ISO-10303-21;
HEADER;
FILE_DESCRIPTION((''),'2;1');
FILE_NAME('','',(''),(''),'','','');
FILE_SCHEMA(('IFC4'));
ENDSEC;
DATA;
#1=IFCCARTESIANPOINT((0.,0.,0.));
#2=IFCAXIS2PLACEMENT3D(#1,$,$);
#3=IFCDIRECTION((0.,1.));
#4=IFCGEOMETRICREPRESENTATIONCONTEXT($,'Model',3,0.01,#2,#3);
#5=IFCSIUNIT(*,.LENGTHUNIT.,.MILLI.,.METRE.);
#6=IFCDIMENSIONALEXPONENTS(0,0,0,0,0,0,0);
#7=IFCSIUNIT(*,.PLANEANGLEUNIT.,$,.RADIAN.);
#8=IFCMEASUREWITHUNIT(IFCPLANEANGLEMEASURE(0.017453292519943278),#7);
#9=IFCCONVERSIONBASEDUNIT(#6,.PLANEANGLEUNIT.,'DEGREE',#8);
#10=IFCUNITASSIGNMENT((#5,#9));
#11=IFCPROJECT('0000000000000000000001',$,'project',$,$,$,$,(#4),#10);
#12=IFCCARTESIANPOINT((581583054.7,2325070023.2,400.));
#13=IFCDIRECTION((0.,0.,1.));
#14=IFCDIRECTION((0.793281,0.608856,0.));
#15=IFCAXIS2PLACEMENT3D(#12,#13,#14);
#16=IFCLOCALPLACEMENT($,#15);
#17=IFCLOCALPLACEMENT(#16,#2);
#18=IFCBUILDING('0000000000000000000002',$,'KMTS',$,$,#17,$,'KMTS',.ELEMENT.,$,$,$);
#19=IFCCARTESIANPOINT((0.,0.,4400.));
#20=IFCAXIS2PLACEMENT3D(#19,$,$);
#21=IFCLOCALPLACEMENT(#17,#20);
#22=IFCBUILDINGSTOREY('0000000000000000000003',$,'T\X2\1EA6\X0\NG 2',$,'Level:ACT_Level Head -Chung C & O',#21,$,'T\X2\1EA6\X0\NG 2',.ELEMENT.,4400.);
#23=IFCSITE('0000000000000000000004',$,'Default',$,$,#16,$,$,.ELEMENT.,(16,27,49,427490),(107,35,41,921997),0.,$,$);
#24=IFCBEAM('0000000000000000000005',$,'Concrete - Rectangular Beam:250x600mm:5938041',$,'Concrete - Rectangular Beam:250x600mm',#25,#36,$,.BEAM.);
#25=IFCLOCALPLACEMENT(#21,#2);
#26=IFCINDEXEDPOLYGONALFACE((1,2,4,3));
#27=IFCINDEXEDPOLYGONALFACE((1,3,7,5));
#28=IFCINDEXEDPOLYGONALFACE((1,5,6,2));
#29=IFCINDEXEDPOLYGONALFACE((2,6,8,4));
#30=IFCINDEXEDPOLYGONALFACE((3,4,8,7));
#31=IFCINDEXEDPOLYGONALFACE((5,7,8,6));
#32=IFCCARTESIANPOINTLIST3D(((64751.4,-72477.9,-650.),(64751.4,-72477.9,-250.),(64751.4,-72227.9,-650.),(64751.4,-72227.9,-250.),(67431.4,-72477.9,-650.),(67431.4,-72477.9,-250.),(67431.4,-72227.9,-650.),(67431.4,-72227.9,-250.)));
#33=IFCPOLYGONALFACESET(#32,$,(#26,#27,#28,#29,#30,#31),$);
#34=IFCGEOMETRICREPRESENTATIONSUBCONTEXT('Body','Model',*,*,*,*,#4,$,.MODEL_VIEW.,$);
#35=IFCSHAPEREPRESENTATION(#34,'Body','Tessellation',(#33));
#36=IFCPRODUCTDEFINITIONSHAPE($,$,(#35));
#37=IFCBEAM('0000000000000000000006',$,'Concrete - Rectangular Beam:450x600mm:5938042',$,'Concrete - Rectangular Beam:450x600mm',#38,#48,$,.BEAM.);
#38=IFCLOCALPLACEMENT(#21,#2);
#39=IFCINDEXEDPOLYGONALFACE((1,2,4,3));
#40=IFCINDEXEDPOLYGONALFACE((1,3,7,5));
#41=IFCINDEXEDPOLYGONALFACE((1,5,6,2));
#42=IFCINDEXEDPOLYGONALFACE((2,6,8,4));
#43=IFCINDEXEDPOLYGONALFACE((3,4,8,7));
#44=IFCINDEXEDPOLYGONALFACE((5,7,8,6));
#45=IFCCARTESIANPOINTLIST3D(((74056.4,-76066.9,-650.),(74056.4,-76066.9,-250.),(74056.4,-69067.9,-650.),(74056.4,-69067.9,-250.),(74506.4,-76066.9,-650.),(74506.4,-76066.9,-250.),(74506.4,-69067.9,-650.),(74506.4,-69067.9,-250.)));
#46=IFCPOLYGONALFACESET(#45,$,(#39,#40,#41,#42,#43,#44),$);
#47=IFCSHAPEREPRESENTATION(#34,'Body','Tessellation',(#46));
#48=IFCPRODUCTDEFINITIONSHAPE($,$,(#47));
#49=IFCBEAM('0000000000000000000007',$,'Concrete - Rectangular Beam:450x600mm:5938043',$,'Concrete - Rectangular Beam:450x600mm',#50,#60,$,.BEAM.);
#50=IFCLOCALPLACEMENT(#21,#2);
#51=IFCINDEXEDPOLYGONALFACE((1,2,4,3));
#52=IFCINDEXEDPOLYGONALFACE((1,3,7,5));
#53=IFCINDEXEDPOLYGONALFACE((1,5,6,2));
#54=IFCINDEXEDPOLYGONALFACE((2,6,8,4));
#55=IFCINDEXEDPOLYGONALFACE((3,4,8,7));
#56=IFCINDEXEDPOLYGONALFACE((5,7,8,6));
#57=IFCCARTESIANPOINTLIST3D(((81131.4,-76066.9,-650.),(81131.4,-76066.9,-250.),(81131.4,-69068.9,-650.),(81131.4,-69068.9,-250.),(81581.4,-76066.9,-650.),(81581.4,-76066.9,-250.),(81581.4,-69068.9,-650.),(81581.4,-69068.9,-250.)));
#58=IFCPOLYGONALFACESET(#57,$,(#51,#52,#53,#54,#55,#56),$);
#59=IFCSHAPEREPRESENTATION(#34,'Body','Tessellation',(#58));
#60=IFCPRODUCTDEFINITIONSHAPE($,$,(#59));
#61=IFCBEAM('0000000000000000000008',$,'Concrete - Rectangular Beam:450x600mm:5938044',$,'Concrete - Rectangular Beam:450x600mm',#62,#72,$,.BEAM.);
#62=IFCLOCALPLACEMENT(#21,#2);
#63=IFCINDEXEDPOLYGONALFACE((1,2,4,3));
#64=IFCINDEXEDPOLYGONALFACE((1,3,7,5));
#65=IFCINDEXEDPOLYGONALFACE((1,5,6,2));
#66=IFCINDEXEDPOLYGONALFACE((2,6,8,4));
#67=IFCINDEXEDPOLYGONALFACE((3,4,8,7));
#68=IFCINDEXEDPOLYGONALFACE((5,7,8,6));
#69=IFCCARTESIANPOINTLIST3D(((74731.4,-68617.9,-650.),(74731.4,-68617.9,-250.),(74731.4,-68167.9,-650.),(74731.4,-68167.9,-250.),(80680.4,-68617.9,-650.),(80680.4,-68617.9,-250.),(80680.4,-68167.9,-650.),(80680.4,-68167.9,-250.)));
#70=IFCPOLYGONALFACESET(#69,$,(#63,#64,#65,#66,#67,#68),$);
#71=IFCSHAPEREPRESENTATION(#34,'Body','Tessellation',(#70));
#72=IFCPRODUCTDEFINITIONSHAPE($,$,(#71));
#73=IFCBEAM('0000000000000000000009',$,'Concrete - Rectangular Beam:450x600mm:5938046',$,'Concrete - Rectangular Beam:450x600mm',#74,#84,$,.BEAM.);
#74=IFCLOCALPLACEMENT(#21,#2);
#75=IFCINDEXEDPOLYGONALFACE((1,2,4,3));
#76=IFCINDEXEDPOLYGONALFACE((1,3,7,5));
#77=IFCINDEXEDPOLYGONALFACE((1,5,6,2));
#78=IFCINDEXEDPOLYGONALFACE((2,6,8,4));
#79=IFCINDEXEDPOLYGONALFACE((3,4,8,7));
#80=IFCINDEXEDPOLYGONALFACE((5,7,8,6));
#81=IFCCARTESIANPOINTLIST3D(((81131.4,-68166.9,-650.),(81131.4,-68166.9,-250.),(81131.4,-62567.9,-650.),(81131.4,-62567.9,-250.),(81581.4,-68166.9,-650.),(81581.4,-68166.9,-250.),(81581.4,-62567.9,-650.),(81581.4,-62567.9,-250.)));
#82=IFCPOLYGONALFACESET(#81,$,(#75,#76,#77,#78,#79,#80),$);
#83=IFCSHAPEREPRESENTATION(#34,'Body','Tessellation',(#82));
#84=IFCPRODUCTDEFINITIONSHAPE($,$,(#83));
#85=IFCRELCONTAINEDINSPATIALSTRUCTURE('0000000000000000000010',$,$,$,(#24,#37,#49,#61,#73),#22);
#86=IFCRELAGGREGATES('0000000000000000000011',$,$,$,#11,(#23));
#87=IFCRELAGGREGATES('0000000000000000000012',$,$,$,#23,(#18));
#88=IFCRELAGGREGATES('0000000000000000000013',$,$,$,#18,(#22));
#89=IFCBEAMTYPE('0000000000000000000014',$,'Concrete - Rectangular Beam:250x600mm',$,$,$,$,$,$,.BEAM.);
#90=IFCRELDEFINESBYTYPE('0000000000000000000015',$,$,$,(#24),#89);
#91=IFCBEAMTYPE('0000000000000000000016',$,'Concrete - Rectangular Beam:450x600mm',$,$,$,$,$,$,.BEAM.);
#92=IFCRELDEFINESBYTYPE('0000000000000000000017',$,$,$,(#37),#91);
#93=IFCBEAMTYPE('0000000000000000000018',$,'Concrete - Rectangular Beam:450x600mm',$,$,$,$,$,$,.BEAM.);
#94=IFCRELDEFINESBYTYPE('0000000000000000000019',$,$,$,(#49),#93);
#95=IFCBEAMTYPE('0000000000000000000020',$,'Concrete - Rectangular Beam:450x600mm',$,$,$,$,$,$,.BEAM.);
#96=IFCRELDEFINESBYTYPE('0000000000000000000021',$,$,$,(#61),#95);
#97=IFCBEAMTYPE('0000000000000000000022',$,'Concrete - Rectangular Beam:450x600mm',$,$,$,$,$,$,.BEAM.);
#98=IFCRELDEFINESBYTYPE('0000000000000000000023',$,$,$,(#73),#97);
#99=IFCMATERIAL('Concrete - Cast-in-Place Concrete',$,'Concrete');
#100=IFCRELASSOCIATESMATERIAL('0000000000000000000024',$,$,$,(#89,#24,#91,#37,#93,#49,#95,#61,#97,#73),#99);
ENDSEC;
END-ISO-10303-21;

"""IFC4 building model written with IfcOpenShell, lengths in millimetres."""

from ifc_helpers import new_model, entity, si_unit, converted_unit, direction, frame, origin, place, context, subcontext, project, spatial, indexed_curve, outline, extrude, source, transform, mapped, material, type_object, type_shapes, element, save


model = new_model("IFC4")

# Units and contexts
model_context = context("Model", 3, precision=0.01, world=origin(), true_north=direction((0.0, 1.0)))
body_context = subcontext(model_context, "Body", "Model", "MODEL_VIEW")
ifc_project = project(units=[si_unit("LENGTHUNIT", "METRE", prefix="MILLI"), converted_unit("PLANEANGLEUNIT", "DEGREE", entity("IfcPlaneAngleMeasure", 0.017453292519943278), si_unit("PLANEANGLEUNIT", "RADIAN"), dimensions=[0, 0, 0, 0, 0, 0, 0])], contexts=[model_context])

# Site, building, storey
site_placement = place(None, frame((581583054.7, 2325070023.2, 400.0), z_axis=(0.0, 0.0, 1.0), x_axis=(0.793281, 0.608856, 0.0)))
site = spatial("IfcSite", under=ifc_project, at=site_placement, Name="Default", CompositionType="ELEMENT", RefLatitude=(16, 27, 49, 427490), RefLongitude=(107, 35, 41, 921997), RefElevation=0.0)
building_placement = place(site_placement, origin())
building = spatial("IfcBuilding", under=site, at=building_placement, Name="KMTS", LongName="KMTS", CompositionType="ELEMENT")
storey_placement = place(building_placement, frame((0.0, 0.0, 4400.0)))
storey = spatial("IfcBuildingStorey", under=building, at=storey_placement, Name="TẦNG 2", ObjectType="Level:ACT_Level Head -Chung C & O", LongName="TẦNG 2", CompositionType="ELEMENT", Elevation=4400.0)

# Beams
ifc_material_1 = material(Name="Concrete - Cast-in-Place Concrete", Category="Concrete")
beam_type_1 = type_object("IfcBeamType", Name="Concrete - Rectangular Beam:250x600mm", PredefinedType="BEAM", material=ifc_material_1)
shared_shape_1 = source(origin(), body_context, "Body", "SweptSolid", [
    extrude(outline(indexed_curve([(-200.0, -125.0), (200.0, -125.0), (200.0, 125.0), (-200.0, 125.0), (-200.0, -125.0)], self_intersect=False)), frame((64751.4, -72352.9, 3950.0), z_axis=(1.0, 0.0, 0.0), x_axis=(0.0, 0.0, -1.0)), (0.0, 0.0, 1.0), 2680.0),
])
type_shapes(beam_type_1, [shared_shape_1])
beam_1_placement = place(storey_placement, frame((0.0, 0.0, -4400.0)))
element("IfcBeam", 1, at=beam_1_placement, inside=storey, type_object=beam_type_1, material=ifc_material_1, Name="Concrete - Rectangular Beam:250x600mm:5938041", ObjectType="Concrete - Rectangular Beam:250x600mm", PredefinedType="BEAM", context=body_context, shape_type="MappedRepresentation", body=[
    mapped(shared_shape_1, transform((0.0, 0.0, 0.0), scale=1.0)),
])
beam_type_2 = type_object("IfcBeamType", Name="Concrete - Rectangular Beam:450x600mm", PredefinedType="BEAM", material=ifc_material_1)
shared_shape_2 = source(origin(), body_context, "Body", "SweptSolid", [
    extrude(outline(indexed_curve([(-225.0, -200.0), (225.0, -200.0), (225.0, 200.0), (-225.0, 200.0), (-225.0, -200.0)], self_intersect=False)), frame((74281.4, -76066.9, 3950.0), z_axis=(0.0, 1.0, 0.0), x_axis=(-1.0, 0.0, 0.0)), (0.0, 0.0, 1.0), 6999.0),
])
type_shapes(beam_type_2, [shared_shape_2])
beam_2_placement = place(storey_placement, frame((0.0, 0.0, -4400.0)))
element("IfcBeam", 2, at=beam_2_placement, inside=storey, type_object=beam_type_2, material=ifc_material_1, Name="Concrete - Rectangular Beam:450x600mm:5938042", ObjectType="Concrete - Rectangular Beam:450x600mm", PredefinedType="BEAM", context=body_context, shape_type="MappedRepresentation", body=[
    mapped(shared_shape_2, transform((0.0, 0.0, 0.0), scale=1.0)),
])
beam_type_3 = type_object("IfcBeamType", Name="Concrete - Rectangular Beam:450x600mm", PredefinedType="BEAM", material=ifc_material_1)
shared_shape_3 = source(origin(), body_context, "Body", "SweptSolid", [
    extrude(outline(indexed_curve([(-225.0, -200.0), (225.0, -200.0), (225.0, 200.0), (-225.0, 200.0), (-225.0, -200.0)], self_intersect=False)), frame((81356.4, -76066.9, 3950.0), z_axis=(0.0, 1.0, 0.0), x_axis=(-1.0, 0.0, 0.0)), (0.0, 0.0, 1.0), 6998.0),
])
type_shapes(beam_type_3, [shared_shape_3])
beam_3_placement = place(storey_placement, frame((0.0, 0.0, -4400.0)))
element("IfcBeam", 3, at=beam_3_placement, inside=storey, type_object=beam_type_3, material=ifc_material_1, Name="Concrete - Rectangular Beam:450x600mm:5938043", ObjectType="Concrete - Rectangular Beam:450x600mm", PredefinedType="BEAM", context=body_context, shape_type="MappedRepresentation", body=[
    mapped(shared_shape_3, transform((0.0, 0.0, 0.0), scale=1.0)),
])
beam_type_4 = type_object("IfcBeamType", Name="Concrete - Rectangular Beam:450x600mm", PredefinedType="BEAM", material=ifc_material_1)
shared_shape_4 = source(origin(), body_context, "Body", "SweptSolid", [
    extrude(outline(indexed_curve([(-200.0, -225.0), (200.0, -225.0), (200.0, 225.0), (-200.0, 225.0), (-200.0, -225.0)], self_intersect=False)), frame((74731.4, -68392.9, 3950.0), z_axis=(1.0, 0.0, 0.0), x_axis=(0.0, 0.0, -1.0)), (0.0, 0.0, 1.0), 5949.0),
])
type_shapes(beam_type_4, [shared_shape_4])
beam_4_placement = place(storey_placement, frame((0.0, 0.0, -4400.0)))
element("IfcBeam", 4, at=beam_4_placement, inside=storey, type_object=beam_type_4, material=ifc_material_1, Name="Concrete - Rectangular Beam:450x600mm:5938044", ObjectType="Concrete - Rectangular Beam:450x600mm", PredefinedType="BEAM", context=body_context, shape_type="MappedRepresentation", body=[
    mapped(shared_shape_4, transform((0.0, 0.0, 0.0), scale=1.0)),
])
beam_type_5 = type_object("IfcBeamType", Name="Concrete - Rectangular Beam:450x600mm", PredefinedType="BEAM", material=ifc_material_1)
shared_shape_5 = source(origin(), body_context, "Body", "SweptSolid", [
    extrude(outline(indexed_curve([(-225.0, -200.0), (225.0, -200.0), (225.0, 200.0), (-225.0, 200.0), (-225.0, -200.0)], self_intersect=False)), frame((81356.4, -68166.9, 3950.0), z_axis=(0.0, 1.0, 0.0), x_axis=(-1.0, 0.0, 0.0)), (0.0, 0.0, 1.0), 5599.0),
])
type_shapes(beam_type_5, [shared_shape_5])
beam_5_placement = place(storey_placement, frame((0.0, 0.0, -4400.0)))
element("IfcBeam", 5, at=beam_5_placement, inside=storey, type_object=beam_type_5, material=ifc_material_1, Name="Concrete - Rectangular Beam:450x600mm:5938046", ObjectType="Concrete - Rectangular Beam:450x600mm", PredefinedType="BEAM", context=body_context, shape_type="MappedRepresentation", body=[
    mapped(shared_shape_5, transform((0.0, 0.0, 0.0), scale=1.0)),
])

save(model, "model.ifc")
